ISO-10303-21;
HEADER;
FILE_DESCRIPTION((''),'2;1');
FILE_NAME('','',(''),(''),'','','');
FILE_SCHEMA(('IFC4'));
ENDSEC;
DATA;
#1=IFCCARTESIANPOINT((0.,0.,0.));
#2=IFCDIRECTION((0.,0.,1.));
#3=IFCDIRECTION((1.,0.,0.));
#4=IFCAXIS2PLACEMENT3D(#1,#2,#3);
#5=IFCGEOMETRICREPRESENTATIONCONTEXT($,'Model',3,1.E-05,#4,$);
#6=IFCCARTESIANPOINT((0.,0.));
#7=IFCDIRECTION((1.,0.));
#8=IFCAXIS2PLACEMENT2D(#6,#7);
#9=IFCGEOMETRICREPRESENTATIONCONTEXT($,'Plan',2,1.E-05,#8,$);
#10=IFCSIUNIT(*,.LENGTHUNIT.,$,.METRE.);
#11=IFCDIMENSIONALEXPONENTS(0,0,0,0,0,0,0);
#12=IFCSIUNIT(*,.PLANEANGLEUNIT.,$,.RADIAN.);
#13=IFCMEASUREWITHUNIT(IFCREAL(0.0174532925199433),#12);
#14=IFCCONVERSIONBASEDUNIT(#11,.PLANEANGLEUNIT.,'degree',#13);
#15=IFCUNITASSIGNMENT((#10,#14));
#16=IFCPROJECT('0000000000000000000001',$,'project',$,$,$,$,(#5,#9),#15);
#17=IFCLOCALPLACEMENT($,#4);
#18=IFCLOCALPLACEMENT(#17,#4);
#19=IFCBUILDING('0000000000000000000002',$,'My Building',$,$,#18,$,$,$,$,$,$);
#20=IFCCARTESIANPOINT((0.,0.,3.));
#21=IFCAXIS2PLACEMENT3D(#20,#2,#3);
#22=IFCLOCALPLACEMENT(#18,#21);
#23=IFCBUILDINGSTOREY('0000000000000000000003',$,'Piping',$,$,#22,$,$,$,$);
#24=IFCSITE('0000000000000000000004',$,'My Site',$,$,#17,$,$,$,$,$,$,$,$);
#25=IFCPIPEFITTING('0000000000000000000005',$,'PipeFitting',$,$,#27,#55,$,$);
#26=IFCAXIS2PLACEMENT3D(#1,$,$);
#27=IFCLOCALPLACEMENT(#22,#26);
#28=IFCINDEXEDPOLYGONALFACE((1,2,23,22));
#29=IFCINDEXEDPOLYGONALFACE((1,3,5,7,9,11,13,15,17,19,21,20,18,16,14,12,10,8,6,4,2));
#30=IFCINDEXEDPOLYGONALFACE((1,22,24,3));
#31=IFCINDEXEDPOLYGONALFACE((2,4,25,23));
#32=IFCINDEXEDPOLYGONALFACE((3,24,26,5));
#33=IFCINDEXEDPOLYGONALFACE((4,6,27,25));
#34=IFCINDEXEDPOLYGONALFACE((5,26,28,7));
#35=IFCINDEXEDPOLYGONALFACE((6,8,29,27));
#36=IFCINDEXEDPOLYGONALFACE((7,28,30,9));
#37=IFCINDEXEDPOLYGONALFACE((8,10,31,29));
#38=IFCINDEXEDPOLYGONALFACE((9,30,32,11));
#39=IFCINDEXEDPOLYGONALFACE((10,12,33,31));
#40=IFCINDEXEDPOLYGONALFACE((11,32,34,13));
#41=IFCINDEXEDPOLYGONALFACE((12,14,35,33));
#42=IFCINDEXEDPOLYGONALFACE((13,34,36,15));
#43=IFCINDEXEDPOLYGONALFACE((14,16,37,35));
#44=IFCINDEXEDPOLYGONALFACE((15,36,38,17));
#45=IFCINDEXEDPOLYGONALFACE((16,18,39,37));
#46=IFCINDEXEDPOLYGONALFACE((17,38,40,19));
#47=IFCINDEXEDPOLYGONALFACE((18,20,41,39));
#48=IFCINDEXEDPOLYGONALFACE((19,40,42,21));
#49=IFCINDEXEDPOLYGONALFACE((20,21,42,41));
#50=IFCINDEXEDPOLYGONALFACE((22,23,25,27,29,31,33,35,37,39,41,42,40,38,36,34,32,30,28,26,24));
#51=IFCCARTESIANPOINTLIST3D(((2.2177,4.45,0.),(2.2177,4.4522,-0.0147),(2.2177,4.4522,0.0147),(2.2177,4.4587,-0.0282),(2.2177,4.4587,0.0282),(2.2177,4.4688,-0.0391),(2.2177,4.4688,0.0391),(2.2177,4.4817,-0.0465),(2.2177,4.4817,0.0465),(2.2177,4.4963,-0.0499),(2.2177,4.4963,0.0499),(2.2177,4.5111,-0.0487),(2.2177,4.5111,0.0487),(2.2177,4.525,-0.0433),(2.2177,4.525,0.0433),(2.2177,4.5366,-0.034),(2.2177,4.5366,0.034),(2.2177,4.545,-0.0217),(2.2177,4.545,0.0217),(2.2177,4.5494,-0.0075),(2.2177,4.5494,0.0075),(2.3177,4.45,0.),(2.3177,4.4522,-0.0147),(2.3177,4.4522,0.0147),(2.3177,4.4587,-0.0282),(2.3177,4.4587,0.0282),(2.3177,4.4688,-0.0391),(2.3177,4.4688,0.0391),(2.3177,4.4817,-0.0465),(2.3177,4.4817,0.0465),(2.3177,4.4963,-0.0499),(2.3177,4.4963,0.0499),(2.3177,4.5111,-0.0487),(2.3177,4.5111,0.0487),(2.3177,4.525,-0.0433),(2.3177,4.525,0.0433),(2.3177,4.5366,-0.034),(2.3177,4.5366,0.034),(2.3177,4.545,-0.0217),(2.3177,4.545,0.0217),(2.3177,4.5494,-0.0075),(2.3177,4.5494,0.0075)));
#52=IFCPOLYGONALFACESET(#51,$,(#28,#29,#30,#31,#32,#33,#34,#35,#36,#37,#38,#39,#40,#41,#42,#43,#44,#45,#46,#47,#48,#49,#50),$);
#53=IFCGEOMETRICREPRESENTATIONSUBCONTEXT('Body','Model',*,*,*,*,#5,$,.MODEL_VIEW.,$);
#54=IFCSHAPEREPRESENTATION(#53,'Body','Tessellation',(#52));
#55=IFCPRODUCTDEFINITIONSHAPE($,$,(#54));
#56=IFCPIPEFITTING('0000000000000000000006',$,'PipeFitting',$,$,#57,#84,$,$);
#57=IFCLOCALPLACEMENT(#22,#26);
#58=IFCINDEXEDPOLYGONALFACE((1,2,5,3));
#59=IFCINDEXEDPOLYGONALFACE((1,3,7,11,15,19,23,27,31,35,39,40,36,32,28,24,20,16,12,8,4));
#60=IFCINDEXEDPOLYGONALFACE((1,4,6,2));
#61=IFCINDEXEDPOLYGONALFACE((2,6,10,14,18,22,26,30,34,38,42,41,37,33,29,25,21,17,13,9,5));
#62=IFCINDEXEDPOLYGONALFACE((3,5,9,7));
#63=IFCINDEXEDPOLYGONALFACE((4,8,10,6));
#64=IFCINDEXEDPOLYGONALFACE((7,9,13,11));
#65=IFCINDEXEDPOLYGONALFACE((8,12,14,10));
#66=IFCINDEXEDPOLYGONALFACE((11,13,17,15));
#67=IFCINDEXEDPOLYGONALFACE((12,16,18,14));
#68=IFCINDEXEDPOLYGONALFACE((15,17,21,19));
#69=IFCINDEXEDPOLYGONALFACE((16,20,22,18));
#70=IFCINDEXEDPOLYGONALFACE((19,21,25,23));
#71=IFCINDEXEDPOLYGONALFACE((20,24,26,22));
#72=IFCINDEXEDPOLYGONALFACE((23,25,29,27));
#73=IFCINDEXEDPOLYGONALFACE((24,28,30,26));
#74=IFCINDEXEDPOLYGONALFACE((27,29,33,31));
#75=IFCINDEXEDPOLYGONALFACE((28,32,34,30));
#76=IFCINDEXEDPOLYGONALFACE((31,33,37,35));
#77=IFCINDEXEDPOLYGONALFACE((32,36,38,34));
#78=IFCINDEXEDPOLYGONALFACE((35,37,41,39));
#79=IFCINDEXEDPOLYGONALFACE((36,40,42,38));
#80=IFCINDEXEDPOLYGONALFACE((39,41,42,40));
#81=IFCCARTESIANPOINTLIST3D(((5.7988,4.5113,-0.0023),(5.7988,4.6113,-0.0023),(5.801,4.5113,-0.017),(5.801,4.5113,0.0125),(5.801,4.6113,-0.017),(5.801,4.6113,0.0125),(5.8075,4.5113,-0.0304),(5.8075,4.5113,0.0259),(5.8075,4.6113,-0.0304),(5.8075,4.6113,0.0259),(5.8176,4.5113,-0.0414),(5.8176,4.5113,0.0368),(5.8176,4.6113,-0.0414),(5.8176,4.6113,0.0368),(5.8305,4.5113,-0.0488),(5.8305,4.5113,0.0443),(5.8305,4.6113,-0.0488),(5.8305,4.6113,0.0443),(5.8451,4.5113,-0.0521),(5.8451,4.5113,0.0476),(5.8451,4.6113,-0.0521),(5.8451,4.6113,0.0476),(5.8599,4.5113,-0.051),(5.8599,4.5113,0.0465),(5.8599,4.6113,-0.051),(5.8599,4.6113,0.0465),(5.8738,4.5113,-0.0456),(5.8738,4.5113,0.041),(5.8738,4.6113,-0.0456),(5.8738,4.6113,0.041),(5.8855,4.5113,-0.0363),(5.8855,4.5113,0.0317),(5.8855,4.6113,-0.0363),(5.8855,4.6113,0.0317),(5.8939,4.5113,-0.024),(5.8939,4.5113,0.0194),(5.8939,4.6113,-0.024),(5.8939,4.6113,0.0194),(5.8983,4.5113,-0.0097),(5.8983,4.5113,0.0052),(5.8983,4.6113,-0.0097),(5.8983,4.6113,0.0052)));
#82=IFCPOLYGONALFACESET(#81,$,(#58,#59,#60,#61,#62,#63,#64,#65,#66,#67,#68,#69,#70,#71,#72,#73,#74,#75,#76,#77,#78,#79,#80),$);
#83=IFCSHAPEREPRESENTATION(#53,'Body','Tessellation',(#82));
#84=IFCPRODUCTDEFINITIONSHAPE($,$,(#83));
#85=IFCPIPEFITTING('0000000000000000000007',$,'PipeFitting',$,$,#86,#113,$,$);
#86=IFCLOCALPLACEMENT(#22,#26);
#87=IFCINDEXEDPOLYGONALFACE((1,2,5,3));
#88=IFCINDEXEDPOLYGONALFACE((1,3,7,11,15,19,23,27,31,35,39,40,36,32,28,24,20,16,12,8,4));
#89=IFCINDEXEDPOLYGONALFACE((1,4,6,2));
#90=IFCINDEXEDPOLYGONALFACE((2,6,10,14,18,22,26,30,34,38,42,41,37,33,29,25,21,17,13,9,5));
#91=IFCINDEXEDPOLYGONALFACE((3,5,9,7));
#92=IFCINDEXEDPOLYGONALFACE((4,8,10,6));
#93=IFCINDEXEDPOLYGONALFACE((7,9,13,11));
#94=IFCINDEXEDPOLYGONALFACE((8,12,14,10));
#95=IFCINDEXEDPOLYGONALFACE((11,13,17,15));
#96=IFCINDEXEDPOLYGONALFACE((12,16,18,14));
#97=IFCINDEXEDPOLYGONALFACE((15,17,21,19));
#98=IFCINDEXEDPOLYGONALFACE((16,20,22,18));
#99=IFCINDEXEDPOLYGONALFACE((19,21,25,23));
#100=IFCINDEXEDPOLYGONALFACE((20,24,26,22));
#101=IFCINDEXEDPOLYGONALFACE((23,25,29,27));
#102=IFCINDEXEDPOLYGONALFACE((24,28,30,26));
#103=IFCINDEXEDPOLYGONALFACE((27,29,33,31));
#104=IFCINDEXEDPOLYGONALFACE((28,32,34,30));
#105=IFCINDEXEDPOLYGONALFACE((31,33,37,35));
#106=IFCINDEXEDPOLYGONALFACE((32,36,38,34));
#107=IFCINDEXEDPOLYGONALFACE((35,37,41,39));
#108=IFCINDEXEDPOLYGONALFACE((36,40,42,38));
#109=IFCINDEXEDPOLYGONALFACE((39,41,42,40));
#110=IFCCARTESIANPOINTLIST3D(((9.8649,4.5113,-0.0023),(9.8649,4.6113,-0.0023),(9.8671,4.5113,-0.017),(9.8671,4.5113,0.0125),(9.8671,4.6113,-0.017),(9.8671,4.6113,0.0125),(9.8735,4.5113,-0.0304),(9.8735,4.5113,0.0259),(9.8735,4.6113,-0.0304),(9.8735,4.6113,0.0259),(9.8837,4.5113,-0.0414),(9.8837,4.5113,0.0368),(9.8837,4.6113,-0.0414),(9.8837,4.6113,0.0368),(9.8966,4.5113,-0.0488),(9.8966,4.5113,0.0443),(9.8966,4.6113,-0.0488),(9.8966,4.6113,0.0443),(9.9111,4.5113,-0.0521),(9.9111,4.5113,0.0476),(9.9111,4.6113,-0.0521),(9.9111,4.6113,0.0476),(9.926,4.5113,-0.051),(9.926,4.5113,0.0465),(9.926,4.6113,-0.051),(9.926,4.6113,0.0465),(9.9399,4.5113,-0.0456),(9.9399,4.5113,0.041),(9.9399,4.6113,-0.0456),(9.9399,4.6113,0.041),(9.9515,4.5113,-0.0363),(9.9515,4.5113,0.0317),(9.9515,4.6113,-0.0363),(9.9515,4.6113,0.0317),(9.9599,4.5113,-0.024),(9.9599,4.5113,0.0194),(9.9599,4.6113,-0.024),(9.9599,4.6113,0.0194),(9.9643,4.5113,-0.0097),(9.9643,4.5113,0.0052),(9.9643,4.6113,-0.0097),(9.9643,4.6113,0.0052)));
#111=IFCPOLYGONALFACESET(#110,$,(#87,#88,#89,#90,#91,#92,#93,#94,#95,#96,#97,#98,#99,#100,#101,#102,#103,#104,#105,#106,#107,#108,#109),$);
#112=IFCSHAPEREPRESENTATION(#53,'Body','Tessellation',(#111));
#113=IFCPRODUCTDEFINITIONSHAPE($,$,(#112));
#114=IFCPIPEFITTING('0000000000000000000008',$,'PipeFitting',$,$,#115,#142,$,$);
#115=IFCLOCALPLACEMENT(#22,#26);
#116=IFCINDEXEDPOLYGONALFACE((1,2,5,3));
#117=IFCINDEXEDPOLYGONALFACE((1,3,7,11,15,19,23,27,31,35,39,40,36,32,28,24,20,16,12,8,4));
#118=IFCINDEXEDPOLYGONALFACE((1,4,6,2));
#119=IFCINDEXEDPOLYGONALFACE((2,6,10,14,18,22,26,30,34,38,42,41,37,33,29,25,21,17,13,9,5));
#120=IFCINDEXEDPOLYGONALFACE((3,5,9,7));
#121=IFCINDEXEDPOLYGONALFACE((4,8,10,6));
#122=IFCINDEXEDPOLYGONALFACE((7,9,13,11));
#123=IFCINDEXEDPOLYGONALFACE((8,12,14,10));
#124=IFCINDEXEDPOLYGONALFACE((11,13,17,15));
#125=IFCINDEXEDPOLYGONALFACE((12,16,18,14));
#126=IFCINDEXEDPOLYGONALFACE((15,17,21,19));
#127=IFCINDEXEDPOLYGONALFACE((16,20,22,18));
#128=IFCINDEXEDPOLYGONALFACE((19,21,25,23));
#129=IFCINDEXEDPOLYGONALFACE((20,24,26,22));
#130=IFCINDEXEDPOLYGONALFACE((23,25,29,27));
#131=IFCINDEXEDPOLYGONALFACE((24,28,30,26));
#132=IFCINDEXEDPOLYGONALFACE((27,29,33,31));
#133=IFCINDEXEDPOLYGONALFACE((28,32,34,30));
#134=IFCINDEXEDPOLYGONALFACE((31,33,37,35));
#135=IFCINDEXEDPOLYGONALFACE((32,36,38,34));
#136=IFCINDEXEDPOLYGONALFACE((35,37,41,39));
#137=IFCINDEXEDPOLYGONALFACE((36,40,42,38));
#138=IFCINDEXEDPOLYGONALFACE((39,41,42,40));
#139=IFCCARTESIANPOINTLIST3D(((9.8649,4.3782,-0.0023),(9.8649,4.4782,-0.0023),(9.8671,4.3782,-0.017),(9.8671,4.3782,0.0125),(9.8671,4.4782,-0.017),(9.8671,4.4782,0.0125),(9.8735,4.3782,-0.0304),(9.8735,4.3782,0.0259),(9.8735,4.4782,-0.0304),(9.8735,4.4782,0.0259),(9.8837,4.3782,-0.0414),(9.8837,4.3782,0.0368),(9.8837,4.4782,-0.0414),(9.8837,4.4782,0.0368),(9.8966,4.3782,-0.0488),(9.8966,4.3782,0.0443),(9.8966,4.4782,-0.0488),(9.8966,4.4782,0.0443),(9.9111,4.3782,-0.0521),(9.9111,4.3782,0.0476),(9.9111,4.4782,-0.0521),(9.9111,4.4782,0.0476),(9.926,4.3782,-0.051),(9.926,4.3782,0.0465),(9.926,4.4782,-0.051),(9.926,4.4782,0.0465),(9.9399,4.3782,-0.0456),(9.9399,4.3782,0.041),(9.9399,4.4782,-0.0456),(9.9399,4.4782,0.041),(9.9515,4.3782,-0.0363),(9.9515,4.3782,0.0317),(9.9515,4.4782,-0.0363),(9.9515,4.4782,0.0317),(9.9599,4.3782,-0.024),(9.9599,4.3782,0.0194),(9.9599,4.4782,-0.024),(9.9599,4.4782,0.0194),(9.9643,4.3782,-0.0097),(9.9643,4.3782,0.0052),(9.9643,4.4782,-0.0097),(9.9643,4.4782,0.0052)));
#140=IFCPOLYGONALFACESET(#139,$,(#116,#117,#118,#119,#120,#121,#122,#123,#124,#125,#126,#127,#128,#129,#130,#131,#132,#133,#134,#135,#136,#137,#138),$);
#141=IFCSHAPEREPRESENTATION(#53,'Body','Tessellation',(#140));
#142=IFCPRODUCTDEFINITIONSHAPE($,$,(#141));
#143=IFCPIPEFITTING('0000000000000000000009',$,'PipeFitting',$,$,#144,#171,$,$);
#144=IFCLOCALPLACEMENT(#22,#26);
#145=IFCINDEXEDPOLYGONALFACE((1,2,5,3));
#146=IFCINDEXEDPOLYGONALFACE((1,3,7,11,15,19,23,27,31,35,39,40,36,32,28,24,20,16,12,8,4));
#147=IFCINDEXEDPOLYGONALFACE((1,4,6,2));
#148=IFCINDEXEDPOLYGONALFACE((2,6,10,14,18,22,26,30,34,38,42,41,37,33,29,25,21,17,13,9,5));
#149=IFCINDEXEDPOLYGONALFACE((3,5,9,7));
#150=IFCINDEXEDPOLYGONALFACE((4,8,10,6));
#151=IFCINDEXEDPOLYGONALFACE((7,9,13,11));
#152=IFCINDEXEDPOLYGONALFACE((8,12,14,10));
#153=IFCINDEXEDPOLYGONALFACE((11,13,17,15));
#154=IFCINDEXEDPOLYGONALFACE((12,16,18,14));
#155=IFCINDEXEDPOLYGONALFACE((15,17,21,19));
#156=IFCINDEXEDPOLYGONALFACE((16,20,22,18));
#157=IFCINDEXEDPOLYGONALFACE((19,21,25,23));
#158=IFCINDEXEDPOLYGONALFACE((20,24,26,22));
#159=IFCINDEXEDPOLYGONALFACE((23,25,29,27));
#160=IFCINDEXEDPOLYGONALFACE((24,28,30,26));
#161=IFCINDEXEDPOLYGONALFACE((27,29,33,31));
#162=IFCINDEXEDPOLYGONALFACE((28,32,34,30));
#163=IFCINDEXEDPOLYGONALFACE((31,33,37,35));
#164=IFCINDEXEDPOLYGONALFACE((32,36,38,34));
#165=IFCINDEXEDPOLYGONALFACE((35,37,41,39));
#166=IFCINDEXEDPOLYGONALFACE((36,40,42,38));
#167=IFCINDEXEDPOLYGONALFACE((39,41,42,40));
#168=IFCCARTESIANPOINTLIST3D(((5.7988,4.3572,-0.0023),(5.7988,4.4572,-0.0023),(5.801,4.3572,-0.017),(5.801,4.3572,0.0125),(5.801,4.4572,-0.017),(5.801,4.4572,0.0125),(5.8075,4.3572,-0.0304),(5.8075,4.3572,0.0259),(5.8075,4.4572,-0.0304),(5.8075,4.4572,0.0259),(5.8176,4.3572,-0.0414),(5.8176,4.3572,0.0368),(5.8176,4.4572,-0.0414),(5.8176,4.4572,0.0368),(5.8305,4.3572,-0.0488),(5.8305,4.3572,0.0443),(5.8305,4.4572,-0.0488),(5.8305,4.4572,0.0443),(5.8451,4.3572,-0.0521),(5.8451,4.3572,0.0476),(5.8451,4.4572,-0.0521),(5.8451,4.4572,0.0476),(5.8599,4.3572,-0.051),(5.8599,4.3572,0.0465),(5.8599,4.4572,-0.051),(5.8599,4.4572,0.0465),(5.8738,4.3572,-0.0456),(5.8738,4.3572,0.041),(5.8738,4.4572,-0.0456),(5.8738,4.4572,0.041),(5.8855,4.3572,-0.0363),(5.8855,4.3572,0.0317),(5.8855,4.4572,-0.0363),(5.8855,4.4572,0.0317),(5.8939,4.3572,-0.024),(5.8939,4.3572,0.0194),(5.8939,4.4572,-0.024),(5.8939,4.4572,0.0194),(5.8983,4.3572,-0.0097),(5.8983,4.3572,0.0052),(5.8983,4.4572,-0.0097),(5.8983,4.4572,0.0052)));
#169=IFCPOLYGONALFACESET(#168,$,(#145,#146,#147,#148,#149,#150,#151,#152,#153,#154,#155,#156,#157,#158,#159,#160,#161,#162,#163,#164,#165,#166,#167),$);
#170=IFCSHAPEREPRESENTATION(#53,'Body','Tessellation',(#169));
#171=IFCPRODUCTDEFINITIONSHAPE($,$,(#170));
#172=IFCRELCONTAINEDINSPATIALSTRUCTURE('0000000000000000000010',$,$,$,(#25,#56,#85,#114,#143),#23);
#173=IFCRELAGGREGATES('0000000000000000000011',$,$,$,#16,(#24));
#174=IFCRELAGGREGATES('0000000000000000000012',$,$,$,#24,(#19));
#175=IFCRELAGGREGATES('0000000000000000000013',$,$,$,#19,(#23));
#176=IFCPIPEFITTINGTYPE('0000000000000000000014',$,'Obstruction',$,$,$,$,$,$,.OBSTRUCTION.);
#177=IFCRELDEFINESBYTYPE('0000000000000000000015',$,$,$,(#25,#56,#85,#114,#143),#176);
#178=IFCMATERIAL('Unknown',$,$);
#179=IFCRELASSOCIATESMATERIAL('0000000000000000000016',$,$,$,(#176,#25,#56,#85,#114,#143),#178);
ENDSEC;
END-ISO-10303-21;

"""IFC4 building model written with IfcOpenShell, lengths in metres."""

from ifc_helpers import new_model, entity, si_unit, converted_unit, frame, origin_with_axes, origin_2d_with_axis, place, context, subcontext, project, spatial, circle, extrude, material, material_profile, profile_set, profile_usage, type_object, element, save


model = new_model("IFC4")

# Units and contexts
model_context = context("Model", 3, precision=1e-05, world=origin_with_axes())
plan_context = context("Plan", 2, precision=1e-05, world=origin_2d_with_axis())
body_context = subcontext(model_context, "Body", "Model", "MODEL_VIEW")
ifc_project = project(units=[si_unit("LENGTHUNIT", "METRE"), converted_unit("PLANEANGLEUNIT", "degree", entity("IfcReal", 0.0174532925199433), si_unit("PLANEANGLEUNIT", "RADIAN"), dimensions=[0, 0, 0, 0, 0, 0, 0])], contexts=[model_context, plan_context])

# Site, building, storey
site_placement = place(None, origin_with_axes())
site = spatial("IfcSite", under=ifc_project, at=site_placement, Name="My Site")
building_placement = place(site_placement, origin_with_axes())
building = spatial("IfcBuilding", under=site, at=building_placement, Name="My Building")
storey_placement = place(building_placement, frame((0.0, 0.0, 3.0), z_axis=(0.0, 0.0, 1.0), x_axis=(1.0, 0.0, 0.0)))
storey = spatial("IfcBuildingStorey", under=building, at=storey_placement, Name="Piping")

# Shared definitions
ifc_material = material(Name="Unknown")

# Pipe fittings
ifc_material_profile_1 = material_profile(ifc_material, circle(Radius=0.05))
ifc_profile_set_1 = profile_set([ifc_material_profile_1])
ifc_profile_usage_1 = profile_usage(ifc_profile_set_1, cardinal=5)
pipe_fitting_type_1 = type_object("IfcPipeFittingType", Name="Obstruction", PredefinedType="OBSTRUCTION", material=ifc_profile_set_1)
pipe_fitting_1_placement = place(storey_placement, frame((2.3177, 4.5, 0.0), z_axis=(-1.0, 0.0, 0.0), x_axis=(0.0, -1.0, 0.0)))
element("IfcPipeFitting", 1, at=pipe_fitting_1_placement, inside=storey, type_object=pipe_fitting_type_1, material=ifc_profile_usage_1, Name="PipeFitting", context=body_context, shape_type="SweptSolid", body=[
    extrude(circle(Radius=0.05), origin_with_axes(), (0.0, 0.0, 1.0), 0.1),
])
ifc_profile_usage_2 = profile_usage(ifc_profile_set_1, cardinal=5)
pipe_fitting_2_placement = place(storey_placement, frame((5.8488, 4.5113, -0.0023), z_axis=(0.0, 1.0, 0.0), x_axis=(-1.0, 0.0, 0.0)))
element("IfcPipeFitting", 2, at=pipe_fitting_2_placement, inside=storey, type_object=pipe_fitting_type_1, material=ifc_profile_usage_2, Name="PipeFitting", context=body_context, shape_type="SweptSolid", body=[
    extrude(circle(Radius=0.05), origin_with_axes(), (0.0, 0.0, 1.0), 0.1),
])
ifc_profile_usage_3 = profile_usage(ifc_profile_set_1, cardinal=5)
pipe_fitting_3_placement = place(storey_placement, frame((9.9149, 4.5113, -0.0023), z_axis=(0.0, 1.0, 0.0), x_axis=(-1.0, 0.0, 0.0)))
element("IfcPipeFitting", 3, at=pipe_fitting_3_placement, inside=storey, type_object=pipe_fitting_type_1, material=ifc_profile_usage_3, Name="PipeFitting", context=body_context, shape_type="SweptSolid", body=[
    extrude(circle(Radius=0.05), origin_with_axes(), (0.0, 0.0, 1.0), 0.1),
])
ifc_profile_usage_4 = profile_usage(ifc_profile_set_1, cardinal=5)
pipe_fitting_4_placement = place(storey_placement, frame((9.9149, 4.3782, -0.0023), z_axis=(0.0, 1.0, 0.0), x_axis=(-1.0, 0.0, 0.0)))
element("IfcPipeFitting", 4, at=pipe_fitting_4_placement, inside=storey, type_object=pipe_fitting_type_1, material=ifc_profile_usage_4, Name="PipeFitting", context=body_context, shape_type="SweptSolid", body=[
    extrude(circle(Radius=0.05), origin_with_axes(), (0.0, 0.0, 1.0), 0.1),
])
ifc_profile_usage_5 = profile_usage(ifc_profile_set_1, cardinal=5)
pipe_fitting_5_placement = place(storey_placement, frame((5.8488, 4.3572, -0.0023), z_axis=(0.0, 1.0, 0.0), x_axis=(-1.0, 0.0, 0.0)))
element("IfcPipeFitting", 5, at=pipe_fitting_5_placement, inside=storey, type_object=pipe_fitting_type_1, material=ifc_profile_usage_5, Name="PipeFitting", context=body_context, shape_type="SweptSolid", body=[
    extrude(circle(Radius=0.05), origin_with_axes(), (0.0, 0.0, 1.0), 0.1),
])

save(model, "model.ifc")
